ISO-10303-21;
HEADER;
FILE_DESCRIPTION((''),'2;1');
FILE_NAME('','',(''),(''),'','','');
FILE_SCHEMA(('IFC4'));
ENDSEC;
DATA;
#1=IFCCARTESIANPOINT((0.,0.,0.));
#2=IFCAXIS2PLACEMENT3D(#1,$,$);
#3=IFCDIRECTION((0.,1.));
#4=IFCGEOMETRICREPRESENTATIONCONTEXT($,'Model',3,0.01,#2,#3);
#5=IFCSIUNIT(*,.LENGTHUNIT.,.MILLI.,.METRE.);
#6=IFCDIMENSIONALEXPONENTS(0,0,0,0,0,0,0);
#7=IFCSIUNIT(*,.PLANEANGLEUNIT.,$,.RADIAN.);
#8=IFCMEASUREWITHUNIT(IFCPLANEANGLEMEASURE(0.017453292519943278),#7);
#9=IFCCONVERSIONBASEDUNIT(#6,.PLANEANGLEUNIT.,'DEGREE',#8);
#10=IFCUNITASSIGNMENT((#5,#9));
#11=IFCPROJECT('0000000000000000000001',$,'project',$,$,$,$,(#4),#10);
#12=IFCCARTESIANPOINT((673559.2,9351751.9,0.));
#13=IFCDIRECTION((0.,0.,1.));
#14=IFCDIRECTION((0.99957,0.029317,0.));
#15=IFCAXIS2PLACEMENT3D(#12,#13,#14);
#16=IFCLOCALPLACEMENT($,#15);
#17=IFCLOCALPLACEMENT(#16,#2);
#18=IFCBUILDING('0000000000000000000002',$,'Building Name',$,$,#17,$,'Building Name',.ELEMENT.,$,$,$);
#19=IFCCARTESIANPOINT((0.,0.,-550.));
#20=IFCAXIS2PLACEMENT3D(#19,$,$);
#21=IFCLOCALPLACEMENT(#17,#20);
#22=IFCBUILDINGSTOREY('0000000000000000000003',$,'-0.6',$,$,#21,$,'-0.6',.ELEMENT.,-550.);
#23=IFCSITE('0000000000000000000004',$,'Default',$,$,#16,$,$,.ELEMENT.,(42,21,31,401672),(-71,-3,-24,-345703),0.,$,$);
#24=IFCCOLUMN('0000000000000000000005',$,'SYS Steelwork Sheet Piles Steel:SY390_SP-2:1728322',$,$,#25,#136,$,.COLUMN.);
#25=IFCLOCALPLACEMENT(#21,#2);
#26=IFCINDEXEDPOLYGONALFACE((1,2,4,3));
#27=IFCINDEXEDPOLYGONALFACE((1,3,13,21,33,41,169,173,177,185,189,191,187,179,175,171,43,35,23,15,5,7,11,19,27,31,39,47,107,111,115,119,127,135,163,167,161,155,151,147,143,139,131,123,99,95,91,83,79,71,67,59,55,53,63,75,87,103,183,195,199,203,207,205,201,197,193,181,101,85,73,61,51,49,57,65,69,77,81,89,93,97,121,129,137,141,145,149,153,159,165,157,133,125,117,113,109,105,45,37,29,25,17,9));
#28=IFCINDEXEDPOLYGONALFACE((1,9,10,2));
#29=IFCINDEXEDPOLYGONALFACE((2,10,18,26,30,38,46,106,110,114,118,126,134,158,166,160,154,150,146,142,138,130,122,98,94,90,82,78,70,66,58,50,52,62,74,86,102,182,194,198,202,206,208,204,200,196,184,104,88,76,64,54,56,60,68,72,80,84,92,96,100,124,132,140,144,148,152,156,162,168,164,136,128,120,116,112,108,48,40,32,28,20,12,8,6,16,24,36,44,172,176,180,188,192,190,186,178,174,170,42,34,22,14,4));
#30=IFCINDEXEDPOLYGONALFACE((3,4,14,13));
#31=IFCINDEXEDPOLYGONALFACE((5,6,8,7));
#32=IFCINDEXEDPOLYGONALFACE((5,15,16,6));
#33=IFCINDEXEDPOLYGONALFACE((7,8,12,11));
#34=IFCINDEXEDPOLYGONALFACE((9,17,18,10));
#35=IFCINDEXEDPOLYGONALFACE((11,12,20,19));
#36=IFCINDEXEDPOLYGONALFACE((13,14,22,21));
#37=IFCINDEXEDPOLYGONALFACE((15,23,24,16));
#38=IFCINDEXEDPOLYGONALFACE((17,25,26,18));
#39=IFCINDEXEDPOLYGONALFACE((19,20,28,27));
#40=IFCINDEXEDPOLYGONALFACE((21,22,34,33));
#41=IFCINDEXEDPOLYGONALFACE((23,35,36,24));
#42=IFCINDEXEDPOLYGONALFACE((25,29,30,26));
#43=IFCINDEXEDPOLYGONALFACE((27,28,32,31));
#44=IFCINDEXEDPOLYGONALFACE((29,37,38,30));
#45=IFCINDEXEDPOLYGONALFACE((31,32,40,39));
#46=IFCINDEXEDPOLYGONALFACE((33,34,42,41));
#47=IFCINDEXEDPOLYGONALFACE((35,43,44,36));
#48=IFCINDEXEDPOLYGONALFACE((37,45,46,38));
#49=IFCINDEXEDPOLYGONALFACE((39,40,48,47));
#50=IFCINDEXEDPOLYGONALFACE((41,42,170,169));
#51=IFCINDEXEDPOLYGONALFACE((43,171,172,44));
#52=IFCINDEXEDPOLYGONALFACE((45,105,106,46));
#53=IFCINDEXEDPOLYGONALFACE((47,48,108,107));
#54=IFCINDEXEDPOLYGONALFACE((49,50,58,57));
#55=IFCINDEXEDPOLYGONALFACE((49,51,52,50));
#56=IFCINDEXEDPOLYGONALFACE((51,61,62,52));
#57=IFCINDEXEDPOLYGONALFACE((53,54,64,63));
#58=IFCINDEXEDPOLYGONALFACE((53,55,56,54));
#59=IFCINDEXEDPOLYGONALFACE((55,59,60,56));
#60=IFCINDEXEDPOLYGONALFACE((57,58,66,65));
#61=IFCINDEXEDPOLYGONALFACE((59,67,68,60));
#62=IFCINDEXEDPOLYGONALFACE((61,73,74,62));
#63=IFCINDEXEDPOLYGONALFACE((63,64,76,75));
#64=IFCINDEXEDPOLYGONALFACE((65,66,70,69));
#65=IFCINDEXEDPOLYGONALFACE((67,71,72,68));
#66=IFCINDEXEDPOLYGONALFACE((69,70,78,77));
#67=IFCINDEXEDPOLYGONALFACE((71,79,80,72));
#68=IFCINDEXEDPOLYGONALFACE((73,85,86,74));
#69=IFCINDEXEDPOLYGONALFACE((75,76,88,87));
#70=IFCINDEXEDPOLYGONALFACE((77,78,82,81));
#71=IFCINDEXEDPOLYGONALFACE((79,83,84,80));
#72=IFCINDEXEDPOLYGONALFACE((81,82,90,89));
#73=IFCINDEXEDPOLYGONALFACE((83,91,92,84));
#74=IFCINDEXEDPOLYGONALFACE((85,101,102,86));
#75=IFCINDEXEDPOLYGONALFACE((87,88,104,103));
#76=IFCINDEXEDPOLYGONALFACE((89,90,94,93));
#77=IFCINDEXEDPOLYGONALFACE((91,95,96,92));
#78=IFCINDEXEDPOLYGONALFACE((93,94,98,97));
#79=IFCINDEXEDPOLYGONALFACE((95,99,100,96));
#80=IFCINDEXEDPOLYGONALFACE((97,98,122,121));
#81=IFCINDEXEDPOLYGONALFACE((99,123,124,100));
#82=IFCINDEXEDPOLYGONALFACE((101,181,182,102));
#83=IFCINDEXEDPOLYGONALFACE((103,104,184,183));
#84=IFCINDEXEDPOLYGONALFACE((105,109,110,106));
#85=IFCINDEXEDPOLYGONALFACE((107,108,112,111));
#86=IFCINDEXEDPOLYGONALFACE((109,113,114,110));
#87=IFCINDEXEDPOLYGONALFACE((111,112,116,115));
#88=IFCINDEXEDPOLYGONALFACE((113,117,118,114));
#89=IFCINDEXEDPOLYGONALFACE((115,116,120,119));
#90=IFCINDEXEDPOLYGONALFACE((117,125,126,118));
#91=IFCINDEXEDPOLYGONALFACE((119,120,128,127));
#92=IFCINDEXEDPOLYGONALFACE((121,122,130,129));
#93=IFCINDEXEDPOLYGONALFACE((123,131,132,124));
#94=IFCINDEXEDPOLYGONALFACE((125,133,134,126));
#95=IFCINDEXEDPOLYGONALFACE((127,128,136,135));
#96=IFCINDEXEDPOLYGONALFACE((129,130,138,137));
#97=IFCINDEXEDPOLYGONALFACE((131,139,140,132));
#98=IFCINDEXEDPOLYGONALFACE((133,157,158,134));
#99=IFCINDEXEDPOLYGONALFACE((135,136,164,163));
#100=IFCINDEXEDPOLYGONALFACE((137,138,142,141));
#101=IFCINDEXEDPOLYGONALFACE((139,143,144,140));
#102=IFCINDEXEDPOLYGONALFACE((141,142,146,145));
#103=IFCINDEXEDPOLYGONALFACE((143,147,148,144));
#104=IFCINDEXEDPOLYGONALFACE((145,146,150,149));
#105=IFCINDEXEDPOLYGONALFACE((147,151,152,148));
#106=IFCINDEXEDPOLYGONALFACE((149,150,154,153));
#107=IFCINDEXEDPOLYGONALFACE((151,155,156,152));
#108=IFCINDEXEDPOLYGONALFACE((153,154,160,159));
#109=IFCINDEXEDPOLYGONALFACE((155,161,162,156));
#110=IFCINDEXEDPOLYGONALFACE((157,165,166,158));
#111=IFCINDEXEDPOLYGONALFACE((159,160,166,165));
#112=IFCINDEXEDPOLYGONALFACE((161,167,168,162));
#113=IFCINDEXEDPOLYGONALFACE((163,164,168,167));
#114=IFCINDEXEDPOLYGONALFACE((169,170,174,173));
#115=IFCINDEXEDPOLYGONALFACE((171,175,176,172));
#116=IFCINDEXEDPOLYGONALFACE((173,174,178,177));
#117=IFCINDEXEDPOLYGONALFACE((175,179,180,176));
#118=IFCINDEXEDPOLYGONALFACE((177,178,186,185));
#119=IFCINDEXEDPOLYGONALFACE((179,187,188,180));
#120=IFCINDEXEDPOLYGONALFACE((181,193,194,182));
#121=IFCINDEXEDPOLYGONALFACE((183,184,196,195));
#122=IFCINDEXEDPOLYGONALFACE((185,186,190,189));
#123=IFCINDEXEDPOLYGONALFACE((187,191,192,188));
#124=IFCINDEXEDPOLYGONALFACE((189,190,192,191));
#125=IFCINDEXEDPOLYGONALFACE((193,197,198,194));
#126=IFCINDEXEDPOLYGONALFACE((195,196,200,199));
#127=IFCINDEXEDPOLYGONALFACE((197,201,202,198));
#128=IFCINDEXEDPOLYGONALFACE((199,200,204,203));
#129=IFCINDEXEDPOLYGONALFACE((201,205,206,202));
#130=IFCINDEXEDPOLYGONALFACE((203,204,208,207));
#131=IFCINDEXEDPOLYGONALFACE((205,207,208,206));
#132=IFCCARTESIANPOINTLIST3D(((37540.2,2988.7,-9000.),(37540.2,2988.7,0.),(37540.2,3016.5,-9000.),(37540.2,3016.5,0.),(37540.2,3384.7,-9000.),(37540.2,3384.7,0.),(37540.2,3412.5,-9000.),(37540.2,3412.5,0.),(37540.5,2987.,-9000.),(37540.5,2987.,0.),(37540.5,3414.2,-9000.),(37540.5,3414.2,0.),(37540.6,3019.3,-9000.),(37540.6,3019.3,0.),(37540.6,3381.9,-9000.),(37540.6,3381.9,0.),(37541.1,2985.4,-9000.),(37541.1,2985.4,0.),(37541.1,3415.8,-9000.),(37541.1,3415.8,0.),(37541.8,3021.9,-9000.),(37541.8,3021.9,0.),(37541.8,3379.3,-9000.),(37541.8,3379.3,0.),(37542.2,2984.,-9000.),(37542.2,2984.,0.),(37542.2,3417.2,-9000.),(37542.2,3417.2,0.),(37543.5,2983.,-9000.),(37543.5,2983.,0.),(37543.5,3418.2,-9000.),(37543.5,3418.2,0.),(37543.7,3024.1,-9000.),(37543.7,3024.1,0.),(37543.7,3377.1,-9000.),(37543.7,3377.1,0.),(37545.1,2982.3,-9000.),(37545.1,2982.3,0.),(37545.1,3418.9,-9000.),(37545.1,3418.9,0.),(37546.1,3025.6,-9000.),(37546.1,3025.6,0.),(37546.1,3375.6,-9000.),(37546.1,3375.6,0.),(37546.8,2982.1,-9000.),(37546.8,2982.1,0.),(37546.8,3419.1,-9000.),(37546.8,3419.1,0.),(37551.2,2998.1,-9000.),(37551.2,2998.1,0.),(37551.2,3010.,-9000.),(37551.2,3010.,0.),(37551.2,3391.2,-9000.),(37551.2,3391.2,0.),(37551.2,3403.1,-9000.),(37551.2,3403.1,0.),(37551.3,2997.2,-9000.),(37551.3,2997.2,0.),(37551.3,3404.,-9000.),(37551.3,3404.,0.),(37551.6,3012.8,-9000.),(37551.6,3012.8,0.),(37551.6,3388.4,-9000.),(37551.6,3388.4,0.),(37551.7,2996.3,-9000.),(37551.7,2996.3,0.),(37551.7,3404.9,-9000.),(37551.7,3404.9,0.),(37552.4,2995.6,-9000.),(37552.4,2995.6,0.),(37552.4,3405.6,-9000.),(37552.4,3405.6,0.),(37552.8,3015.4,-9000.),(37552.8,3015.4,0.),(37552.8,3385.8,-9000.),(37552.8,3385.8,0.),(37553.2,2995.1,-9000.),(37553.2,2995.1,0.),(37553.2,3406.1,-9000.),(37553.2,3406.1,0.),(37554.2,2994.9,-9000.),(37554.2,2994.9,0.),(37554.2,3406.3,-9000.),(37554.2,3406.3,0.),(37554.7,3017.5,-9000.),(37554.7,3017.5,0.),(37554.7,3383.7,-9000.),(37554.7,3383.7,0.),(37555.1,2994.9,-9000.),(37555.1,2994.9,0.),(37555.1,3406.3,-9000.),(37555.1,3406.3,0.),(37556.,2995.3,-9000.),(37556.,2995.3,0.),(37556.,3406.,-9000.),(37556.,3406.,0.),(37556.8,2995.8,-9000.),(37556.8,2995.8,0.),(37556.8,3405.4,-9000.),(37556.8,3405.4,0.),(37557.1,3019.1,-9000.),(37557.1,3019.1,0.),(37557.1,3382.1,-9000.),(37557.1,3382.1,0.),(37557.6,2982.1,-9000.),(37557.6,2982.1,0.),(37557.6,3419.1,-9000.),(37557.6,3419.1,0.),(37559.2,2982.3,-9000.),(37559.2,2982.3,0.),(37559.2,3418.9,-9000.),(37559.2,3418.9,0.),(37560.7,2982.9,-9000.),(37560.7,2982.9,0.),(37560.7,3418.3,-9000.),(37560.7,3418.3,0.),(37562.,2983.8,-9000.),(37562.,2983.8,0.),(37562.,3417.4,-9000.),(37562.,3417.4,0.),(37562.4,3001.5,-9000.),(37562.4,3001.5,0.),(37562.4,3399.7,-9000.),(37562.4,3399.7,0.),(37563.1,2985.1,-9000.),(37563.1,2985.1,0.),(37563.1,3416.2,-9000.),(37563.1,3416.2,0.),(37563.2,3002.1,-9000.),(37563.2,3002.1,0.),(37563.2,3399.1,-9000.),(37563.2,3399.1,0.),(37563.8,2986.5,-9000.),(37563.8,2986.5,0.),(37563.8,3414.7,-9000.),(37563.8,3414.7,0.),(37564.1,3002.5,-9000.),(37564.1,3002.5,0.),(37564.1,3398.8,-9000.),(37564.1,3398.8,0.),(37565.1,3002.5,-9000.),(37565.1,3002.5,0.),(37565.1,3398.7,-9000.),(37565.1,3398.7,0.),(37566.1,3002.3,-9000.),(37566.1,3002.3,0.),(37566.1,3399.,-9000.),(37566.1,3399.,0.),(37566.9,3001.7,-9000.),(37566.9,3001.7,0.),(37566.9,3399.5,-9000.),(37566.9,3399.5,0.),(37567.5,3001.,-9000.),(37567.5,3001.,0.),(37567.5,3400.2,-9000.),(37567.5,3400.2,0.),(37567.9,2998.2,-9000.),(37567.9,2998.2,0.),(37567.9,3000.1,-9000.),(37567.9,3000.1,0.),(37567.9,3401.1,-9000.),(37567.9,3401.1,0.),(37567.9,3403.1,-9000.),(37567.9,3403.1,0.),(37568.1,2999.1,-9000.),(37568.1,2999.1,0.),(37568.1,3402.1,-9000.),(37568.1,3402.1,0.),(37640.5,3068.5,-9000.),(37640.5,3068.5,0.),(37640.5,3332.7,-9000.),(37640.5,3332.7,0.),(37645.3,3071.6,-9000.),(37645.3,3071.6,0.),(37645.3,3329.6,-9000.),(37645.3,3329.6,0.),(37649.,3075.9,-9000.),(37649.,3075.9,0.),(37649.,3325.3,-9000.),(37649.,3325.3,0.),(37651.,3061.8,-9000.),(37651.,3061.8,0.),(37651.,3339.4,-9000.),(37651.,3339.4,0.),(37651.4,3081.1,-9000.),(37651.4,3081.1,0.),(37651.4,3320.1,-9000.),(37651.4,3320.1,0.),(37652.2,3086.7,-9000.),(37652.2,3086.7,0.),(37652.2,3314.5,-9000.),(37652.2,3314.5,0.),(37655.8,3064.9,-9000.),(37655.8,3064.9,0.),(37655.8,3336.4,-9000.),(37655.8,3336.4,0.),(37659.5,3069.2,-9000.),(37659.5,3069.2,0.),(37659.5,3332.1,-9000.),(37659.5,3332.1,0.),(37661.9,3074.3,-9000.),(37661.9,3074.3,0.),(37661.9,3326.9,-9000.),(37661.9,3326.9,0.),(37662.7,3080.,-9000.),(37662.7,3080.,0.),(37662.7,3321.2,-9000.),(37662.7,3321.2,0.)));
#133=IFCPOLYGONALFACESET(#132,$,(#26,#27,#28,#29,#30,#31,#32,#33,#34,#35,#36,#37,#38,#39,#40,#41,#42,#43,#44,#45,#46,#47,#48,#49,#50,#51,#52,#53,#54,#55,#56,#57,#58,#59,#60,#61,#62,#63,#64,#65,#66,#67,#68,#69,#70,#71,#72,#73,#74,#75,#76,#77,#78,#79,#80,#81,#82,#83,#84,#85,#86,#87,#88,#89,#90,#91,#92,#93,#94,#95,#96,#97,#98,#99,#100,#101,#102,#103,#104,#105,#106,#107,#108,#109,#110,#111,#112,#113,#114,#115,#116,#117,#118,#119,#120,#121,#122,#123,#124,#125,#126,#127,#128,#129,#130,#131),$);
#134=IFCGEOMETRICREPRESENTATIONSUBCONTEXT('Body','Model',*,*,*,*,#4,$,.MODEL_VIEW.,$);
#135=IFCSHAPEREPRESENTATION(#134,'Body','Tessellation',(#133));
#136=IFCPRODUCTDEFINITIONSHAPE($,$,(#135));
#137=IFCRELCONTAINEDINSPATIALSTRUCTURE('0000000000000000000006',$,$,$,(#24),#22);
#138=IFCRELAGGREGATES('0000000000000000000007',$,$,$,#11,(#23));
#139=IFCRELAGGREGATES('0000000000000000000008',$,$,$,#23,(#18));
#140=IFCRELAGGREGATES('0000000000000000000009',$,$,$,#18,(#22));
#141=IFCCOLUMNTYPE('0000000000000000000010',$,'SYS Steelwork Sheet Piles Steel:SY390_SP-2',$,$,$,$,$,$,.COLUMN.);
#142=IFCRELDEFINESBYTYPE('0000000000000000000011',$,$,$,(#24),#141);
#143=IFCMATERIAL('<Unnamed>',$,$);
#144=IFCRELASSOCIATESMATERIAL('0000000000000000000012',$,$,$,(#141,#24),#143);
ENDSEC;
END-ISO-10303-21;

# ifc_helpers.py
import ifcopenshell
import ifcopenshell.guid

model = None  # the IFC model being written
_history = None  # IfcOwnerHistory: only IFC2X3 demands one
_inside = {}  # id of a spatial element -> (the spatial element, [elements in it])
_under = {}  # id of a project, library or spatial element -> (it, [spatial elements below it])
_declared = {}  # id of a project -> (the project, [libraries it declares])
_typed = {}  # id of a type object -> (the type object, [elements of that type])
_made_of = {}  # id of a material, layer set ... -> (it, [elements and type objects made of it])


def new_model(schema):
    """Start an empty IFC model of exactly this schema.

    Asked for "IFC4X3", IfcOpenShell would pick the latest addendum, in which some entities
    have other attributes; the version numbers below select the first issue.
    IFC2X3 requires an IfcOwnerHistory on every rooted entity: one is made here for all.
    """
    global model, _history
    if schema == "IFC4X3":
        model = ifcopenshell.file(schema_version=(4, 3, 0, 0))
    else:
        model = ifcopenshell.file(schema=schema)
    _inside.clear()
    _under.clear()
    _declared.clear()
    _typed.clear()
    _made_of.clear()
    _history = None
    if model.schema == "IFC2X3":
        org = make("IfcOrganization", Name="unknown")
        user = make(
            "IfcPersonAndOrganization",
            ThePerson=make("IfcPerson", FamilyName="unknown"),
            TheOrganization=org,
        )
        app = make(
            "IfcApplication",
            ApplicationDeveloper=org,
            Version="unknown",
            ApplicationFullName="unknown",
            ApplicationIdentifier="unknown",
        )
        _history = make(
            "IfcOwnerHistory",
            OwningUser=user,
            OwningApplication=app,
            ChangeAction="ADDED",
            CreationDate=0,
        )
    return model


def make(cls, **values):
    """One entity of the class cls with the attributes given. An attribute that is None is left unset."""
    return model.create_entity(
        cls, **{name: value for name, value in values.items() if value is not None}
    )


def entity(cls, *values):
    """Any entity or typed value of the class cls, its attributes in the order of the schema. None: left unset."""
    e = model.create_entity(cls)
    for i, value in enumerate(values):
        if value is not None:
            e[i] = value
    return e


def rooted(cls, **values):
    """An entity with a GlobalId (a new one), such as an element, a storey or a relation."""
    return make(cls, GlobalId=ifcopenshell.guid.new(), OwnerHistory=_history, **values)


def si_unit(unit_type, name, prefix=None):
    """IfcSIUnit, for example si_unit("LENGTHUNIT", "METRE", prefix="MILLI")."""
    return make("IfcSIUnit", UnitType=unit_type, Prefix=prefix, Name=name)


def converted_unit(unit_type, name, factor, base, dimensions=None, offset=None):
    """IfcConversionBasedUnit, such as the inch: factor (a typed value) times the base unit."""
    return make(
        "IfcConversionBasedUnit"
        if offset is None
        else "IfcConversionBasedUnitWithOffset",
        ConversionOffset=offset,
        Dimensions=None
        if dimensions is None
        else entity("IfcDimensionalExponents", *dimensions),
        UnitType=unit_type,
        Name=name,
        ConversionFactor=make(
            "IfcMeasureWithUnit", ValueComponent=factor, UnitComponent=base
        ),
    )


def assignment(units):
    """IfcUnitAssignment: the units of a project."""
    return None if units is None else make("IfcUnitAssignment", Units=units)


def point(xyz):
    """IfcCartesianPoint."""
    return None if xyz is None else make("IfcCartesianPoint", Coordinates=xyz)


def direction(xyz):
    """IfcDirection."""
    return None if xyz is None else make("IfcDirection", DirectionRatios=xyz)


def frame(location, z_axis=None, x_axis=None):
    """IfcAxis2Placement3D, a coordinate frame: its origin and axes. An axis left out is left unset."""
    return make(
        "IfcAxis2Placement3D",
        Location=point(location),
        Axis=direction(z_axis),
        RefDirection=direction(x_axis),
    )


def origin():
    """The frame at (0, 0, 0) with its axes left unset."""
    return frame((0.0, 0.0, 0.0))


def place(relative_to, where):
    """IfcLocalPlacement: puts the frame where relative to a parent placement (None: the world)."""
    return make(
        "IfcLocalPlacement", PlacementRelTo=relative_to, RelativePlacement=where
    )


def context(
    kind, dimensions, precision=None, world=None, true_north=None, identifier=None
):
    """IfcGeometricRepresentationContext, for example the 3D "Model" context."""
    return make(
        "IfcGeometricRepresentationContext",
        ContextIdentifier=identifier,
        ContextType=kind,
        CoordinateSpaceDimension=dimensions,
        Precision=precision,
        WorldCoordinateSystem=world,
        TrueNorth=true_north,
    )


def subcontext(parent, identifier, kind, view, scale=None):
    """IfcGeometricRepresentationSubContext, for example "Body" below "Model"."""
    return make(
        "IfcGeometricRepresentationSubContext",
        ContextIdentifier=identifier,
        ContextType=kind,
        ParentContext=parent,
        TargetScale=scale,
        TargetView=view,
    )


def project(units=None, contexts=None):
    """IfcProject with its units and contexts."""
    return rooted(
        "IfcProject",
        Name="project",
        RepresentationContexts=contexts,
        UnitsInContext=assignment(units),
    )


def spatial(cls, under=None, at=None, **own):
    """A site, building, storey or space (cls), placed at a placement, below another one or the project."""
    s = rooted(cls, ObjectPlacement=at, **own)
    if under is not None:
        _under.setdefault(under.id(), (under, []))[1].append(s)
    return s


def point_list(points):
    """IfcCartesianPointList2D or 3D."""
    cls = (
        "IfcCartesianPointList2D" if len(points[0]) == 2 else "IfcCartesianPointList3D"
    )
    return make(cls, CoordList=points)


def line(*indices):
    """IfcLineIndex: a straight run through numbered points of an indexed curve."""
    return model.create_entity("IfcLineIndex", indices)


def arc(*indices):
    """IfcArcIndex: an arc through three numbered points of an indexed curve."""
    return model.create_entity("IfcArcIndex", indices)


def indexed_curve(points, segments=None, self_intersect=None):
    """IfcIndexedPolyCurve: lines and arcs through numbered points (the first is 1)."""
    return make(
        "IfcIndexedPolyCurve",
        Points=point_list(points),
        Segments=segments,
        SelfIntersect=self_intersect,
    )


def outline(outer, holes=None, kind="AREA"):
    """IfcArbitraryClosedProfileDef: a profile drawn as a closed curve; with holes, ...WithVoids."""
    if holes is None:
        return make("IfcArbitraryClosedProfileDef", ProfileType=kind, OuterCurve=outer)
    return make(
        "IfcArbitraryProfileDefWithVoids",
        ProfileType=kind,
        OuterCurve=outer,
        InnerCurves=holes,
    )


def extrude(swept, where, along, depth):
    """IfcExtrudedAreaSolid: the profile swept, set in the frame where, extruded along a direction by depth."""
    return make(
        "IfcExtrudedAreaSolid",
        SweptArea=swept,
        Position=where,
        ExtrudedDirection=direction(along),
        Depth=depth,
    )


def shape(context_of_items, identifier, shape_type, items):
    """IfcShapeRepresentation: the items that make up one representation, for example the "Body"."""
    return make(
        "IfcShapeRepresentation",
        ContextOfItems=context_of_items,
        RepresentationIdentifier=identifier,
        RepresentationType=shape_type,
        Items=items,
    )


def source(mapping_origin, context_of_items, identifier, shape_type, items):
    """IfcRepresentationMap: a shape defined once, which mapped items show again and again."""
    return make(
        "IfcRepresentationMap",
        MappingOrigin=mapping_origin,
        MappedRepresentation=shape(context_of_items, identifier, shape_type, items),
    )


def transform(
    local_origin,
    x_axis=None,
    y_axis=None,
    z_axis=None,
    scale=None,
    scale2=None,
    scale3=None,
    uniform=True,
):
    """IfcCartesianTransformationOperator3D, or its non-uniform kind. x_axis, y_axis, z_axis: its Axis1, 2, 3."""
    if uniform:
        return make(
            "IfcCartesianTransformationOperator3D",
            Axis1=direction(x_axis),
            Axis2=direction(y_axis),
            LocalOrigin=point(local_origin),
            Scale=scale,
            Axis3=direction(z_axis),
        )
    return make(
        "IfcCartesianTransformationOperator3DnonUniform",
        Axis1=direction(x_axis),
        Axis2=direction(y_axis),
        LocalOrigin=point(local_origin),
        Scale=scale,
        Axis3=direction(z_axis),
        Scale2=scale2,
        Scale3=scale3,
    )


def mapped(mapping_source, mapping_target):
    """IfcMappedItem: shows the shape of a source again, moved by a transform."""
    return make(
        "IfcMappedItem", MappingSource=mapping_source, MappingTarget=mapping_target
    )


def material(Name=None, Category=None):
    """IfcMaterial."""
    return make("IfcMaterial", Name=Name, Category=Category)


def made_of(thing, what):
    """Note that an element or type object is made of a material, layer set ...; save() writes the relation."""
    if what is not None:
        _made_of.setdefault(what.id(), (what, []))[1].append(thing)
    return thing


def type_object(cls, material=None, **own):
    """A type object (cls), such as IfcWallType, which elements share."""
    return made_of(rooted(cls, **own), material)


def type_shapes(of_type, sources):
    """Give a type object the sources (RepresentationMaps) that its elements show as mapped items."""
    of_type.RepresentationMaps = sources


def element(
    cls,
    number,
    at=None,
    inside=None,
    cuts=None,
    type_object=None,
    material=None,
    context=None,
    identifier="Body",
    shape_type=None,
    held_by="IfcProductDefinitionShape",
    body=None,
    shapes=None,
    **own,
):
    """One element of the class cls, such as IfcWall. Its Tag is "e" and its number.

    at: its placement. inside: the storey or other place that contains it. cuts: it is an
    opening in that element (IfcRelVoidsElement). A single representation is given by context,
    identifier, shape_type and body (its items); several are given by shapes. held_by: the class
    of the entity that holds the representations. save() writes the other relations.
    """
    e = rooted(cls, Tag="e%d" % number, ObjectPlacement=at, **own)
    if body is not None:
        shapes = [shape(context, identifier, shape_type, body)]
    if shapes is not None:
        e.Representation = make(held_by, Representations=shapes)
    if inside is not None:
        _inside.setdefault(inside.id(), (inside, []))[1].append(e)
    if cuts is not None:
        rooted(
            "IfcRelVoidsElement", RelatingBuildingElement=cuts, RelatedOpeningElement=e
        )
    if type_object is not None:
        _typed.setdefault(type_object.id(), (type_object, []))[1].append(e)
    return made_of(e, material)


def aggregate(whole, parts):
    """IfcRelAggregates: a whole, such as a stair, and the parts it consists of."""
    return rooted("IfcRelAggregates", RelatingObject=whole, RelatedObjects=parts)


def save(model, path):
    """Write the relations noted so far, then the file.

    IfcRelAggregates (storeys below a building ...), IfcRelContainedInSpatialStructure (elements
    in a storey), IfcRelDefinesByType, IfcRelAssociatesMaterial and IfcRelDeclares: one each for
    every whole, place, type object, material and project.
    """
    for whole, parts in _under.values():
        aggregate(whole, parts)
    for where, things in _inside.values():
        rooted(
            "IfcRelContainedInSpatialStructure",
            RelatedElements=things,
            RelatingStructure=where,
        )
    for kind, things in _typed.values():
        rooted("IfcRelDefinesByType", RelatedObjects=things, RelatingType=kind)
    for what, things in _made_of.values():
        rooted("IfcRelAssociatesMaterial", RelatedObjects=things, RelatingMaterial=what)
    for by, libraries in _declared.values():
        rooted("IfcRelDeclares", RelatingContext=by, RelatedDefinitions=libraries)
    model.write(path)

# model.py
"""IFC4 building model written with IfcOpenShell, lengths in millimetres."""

from ifc_helpers import new_model, entity, si_unit, converted_unit, direction, frame, origin, place, context, subcontext, project, spatial, line, arc, indexed_curve, outline, extrude, source, transform, mapped, material, type_object, type_shapes, element, save


model = new_model("IFC4")

# Units and contexts
model_context = context("Model", 3, precision=0.01, world=origin(), true_north=direction((0.0, 1.0)))
body_context = subcontext(model_context, "Body", "Model", "MODEL_VIEW")
ifc_project = project(units=[si_unit("LENGTHUNIT", "METRE", prefix="MILLI"), converted_unit("PLANEANGLEUNIT", "DEGREE", entity("IfcPlaneAngleMeasure", 0.017453292519943278), si_unit("PLANEANGLEUNIT", "RADIAN"), dimensions=[0, 0, 0, 0, 0, 0, 0])], contexts=[model_context])

# Site, building, storey
site_placement = place(None, frame((673559.2, 9351751.9, 0.0), z_axis=(0.0, 0.0, 1.0), x_axis=(0.99957, 0.029317, 0.0)))
site = spatial("IfcSite", under=ifc_project, at=site_placement, Name="Default", CompositionType="ELEMENT", RefLatitude=(42, 21, 31, 401672), RefLongitude=(-71, -3, -24, -345703), RefElevation=0.0)
building_placement = place(site_placement, origin())
building = spatial("IfcBuilding", under=site, at=building_placement, Name="Building Name", LongName="Building Name", CompositionType="ELEMENT")
storey_placement = place(building_placement, frame((0.0, 0.0, -550.0)))
storey = spatial("IfcBuildingStorey", under=building, at=storey_placement, Name="-0.6", LongName="-0.6", CompositionType="ELEMENT", Elevation=-550.0)

# Column
ifc_material_1 = material(Name="<Unnamed>")
column_type = type_object("IfcColumnType", Name="SYS Steelwork Sheet Piles Steel:SY390_SP-2", PredefinedType="COLUMN", material=ifc_material_1)
shared_shape = source(origin(), body_context, "Body", "SweptSolid", [
    extrude(outline(indexed_curve([(-120.6, 84.7), (-131.4, 81.6), (-138.8, 73.0), (-181.5, -20.9), (-185.2, -25.2), (-190.6, -26.8), (-202.5, -26.8), (-205.5, -24.8), (-204.8, -21.2), (-199.1, -15.5), (-198.6, -11.5), (-202.5, -10.1), (-214.1, -14.2), (-217.3, -16.6), (-218.5, -20.4), (-218.5, -31.2), (-216.6, -35.8), (-211.9, -37.8), (-184.1, -37.8), (-178.7, -36.2), (-175.0, -31.9), (-132.1, 62.5), (-124.7, 71.1), (-113.9, 74.2), (113.9, 74.2), (124.7, 71.1), (132.1, 62.5), (175.0, -31.9), (178.7, -36.2), (184.1, -37.8), (211.9, -37.8), (216.6, -35.8), (218.5, -31.2), (218.5, -20.4), (217.3, -16.6), (214.1, -14.2), (202.5, -10.1), (198.6, -11.5), (199.1, -15.5), (204.8, -21.2), (205.5, -24.8), (202.5, -26.8), (190.6, -26.8), (185.2, -25.2), (181.5, -20.9), (138.8, 73.0), (131.4, 81.6), (120.6, 84.7)], segments=[arc(1, 2, 3), line(3, 4), arc(4, 5, 6), line(6, 7), arc(7, 8, 9), line(9, 10), arc(10, 11, 12), line(12, 13), arc(13, 14, 15), line(15, 16), arc(16, 17, 18), line(18, 19), arc(19, 20, 21), line(21, 22), arc(22, 23, 24), line(24, 25), arc(25, 26, 27), line(27, 28), arc(28, 29, 30), line(30, 31), arc(31, 32, 33), line(33, 34), arc(34, 35, 36), line(36, 37), arc(37, 38, 39), line(39, 40), arc(40, 41, 42), line(42, 43), arc(43, 44, 45), line(45, 46), arc(46, 47, 48), line(48, 1)], self_intersect=False)), frame((0.0, 15.3, -9550.0)), (0.0, 0.0, 1.0), 9000.0),
])
type_shapes(column_type, [shared_shape])
for number, where, z_axis, x_axis, name in (
    (1, (37562.7, 3200.6, 550.0), (0.0, 0.0, 1.0), (0.0, -1.0, 0.0), "SYS Steelwork Sheet Piles Steel:SY390_SP-2:1728322"),
):
    element("IfcColumn", number, at=place(storey_placement, frame(where, z_axis=z_axis, x_axis=x_axis)), inside=storey, type_object=column_type, material=ifc_material_1, Name=name, PredefinedType="COLUMN", context=body_context, shape_type="MappedRepresentation", body=[
        mapped(shared_shape, transform((0.0, 0.0, 0.0), scale=1.0)),
    ])

save(model, "model.ifc")
